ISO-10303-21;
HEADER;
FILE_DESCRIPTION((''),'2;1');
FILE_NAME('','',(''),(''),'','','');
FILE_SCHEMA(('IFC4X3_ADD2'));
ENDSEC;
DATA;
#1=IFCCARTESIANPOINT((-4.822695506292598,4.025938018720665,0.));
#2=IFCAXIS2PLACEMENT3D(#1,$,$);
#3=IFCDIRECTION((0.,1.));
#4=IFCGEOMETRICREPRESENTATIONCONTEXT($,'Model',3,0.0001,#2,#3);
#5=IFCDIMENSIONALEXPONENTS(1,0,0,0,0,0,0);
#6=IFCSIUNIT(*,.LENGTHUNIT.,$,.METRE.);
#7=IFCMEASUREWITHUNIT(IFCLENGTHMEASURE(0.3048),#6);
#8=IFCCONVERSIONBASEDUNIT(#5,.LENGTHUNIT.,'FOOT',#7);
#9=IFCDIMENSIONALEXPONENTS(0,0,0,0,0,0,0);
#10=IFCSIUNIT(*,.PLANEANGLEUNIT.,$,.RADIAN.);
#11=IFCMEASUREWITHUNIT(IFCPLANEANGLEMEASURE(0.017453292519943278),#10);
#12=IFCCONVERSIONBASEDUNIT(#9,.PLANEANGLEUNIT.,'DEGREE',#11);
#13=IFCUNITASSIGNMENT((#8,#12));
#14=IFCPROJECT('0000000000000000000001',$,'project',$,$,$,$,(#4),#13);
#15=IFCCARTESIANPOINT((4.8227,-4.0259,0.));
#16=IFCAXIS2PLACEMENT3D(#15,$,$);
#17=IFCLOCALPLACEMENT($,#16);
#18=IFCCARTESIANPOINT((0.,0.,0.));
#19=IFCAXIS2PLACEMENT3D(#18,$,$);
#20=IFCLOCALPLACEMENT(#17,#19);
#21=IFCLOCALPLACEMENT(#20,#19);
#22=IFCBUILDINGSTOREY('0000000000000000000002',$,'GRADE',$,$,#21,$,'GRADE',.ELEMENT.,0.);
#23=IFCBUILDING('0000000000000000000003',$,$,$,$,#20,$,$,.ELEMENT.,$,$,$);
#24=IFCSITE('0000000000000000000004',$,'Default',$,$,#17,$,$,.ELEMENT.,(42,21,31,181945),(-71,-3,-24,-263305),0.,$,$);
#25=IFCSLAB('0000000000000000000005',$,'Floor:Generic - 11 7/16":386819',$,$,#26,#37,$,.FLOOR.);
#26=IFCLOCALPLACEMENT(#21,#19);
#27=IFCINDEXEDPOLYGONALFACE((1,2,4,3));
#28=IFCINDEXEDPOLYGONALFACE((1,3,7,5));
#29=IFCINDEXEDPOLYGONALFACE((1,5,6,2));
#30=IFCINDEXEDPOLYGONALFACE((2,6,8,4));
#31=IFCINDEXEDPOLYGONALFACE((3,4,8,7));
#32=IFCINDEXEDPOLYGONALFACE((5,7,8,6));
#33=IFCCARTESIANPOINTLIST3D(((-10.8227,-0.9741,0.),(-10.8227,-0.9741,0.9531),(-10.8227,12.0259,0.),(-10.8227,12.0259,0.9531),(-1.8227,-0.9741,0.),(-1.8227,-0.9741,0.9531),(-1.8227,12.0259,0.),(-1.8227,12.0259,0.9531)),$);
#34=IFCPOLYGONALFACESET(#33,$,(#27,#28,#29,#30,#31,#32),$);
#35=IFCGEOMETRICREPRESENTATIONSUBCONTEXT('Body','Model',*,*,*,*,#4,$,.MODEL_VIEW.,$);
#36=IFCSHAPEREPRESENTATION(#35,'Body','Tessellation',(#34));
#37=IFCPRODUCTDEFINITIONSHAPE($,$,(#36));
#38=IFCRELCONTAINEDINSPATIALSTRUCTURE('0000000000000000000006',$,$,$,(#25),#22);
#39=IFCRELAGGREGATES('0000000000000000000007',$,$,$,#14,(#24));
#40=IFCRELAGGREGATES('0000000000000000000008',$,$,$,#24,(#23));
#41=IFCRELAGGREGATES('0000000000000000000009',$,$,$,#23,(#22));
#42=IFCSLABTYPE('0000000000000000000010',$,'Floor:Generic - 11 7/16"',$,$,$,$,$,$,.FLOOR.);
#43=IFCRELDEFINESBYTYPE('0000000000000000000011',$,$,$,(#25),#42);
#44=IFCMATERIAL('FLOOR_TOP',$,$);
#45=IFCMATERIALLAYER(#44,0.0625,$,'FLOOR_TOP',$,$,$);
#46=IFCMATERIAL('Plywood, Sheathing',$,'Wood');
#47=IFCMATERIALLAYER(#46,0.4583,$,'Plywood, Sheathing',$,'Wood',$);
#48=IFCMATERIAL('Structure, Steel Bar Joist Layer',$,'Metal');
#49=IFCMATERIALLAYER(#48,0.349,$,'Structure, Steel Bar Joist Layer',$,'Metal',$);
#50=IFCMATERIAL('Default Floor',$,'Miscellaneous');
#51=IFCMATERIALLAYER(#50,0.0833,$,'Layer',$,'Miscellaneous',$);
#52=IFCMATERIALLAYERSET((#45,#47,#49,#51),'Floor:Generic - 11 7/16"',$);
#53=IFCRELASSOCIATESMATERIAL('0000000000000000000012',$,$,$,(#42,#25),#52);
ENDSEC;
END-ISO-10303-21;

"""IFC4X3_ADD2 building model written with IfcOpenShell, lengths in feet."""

from ifc_helpers import new_model, entity, si_unit, converted_unit, direction, frame, frame_2d, origin, place, context, subcontext, project, spatial, rectangle, extrude, material, layer, layer_set, layer_usage, type_object, element, save


model = new_model("IFC4X3_ADD2")

# Units and contexts
model_context = context("Model", 3, precision=0.0001, world=frame((-4.822695506292598, 4.025938018720665, 0.0)), true_north=direction((0.0, 1.0)))
body_context = subcontext(model_context, "Body", "Model", "MODEL_VIEW")
ifc_project = project(units=[converted_unit("LENGTHUNIT", "FOOT", entity("IfcLengthMeasure", 0.3048), si_unit("LENGTHUNIT", "METRE"), dimensions=[1, 0, 0, 0, 0, 0, 0]), converted_unit("PLANEANGLEUNIT", "DEGREE", entity("IfcPlaneAngleMeasure", 0.017453292519943278), si_unit("PLANEANGLEUNIT", "RADIAN"), dimensions=[0, 0, 0, 0, 0, 0, 0])], contexts=[model_context])

# Site, building, storey
site_placement = place(None, frame((4.8227, -4.0259, 0.0)))
site = spatial("IfcSite", under=ifc_project, at=site_placement, Name="Default", CompositionType="ELEMENT", RefLatitude=(42, 21, 31, 181945), RefLongitude=(-71, -3, -24, -263305), RefElevation=0.0)
building_placement = place(site_placement, origin())
building = spatial("IfcBuilding", under=site, at=building_placement, CompositionType="ELEMENT")
storey_placement = place(building_placement, origin())
storey = spatial("IfcBuildingStorey", under=building, at=storey_placement, Name="GRADE", LongName="GRADE", CompositionType="ELEMENT", Elevation=0.0)

# Slab
ifc_material_1 = material(Name="FLOOR_TOP")
ifc_layer_1 = layer(ifc_material_1, 0.0625, Name="FLOOR_TOP")
ifc_material_2 = material(Name="Plywood, Sheathing", Category="Wood")
ifc_layer_2 = layer(ifc_material_2, 0.4583, Name="Plywood, Sheathing", Category="Wood")
ifc_material_3 = material(Name="Structure, Steel Bar Joist Layer", Category="Metal")
ifc_layer_3 = layer(ifc_material_3, 0.349, Name="Structure, Steel Bar Joist Layer", Category="Metal")
ifc_material_4 = material(Name="Default Floor", Category="Miscellaneous")
ifc_layer_4 = layer(ifc_material_4, 0.0833, Name="Layer", Category="Miscellaneous")
ifc_layer_set_1 = layer_set([ifc_layer_1, ifc_layer_2, ifc_layer_3, ifc_layer_4], Name="Floor:Generic - 11 7/16\"")
ifc_layer_usage_1 = layer_usage(ifc_layer_set_1, "AXIS3", "POSITIVE", 0.0)
slab_type_1 = type_object("IfcSlabType", Name="Floor:Generic - 11 7/16\"", PredefinedType="FLOOR", material=ifc_layer_set_1)
slab_1_placement = place(storey_placement, origin())
element("IfcSlab", 1, at=slab_1_placement, inside=storey, type_object=slab_type_1, material=ifc_layer_usage_1, Name="Floor:Generic - 11 7/16\":386819", PredefinedType="FLOOR", context=body_context, shape_type="SweptSolid", body=[
    extrude(rectangle(XDim=13.0, YDim=9.0, at=frame_2d((0.0, 0.0), x_axis=(1.0, 0.0))), frame((-6.3227, 5.5259, 0.9531), z_axis=(0.0, 0.0, -1.0), x_axis=(0.0, 1.0, 0.0)), (0.0, 0.0, 1.0), 0.9531),
])

save(model, "model.ifc")
